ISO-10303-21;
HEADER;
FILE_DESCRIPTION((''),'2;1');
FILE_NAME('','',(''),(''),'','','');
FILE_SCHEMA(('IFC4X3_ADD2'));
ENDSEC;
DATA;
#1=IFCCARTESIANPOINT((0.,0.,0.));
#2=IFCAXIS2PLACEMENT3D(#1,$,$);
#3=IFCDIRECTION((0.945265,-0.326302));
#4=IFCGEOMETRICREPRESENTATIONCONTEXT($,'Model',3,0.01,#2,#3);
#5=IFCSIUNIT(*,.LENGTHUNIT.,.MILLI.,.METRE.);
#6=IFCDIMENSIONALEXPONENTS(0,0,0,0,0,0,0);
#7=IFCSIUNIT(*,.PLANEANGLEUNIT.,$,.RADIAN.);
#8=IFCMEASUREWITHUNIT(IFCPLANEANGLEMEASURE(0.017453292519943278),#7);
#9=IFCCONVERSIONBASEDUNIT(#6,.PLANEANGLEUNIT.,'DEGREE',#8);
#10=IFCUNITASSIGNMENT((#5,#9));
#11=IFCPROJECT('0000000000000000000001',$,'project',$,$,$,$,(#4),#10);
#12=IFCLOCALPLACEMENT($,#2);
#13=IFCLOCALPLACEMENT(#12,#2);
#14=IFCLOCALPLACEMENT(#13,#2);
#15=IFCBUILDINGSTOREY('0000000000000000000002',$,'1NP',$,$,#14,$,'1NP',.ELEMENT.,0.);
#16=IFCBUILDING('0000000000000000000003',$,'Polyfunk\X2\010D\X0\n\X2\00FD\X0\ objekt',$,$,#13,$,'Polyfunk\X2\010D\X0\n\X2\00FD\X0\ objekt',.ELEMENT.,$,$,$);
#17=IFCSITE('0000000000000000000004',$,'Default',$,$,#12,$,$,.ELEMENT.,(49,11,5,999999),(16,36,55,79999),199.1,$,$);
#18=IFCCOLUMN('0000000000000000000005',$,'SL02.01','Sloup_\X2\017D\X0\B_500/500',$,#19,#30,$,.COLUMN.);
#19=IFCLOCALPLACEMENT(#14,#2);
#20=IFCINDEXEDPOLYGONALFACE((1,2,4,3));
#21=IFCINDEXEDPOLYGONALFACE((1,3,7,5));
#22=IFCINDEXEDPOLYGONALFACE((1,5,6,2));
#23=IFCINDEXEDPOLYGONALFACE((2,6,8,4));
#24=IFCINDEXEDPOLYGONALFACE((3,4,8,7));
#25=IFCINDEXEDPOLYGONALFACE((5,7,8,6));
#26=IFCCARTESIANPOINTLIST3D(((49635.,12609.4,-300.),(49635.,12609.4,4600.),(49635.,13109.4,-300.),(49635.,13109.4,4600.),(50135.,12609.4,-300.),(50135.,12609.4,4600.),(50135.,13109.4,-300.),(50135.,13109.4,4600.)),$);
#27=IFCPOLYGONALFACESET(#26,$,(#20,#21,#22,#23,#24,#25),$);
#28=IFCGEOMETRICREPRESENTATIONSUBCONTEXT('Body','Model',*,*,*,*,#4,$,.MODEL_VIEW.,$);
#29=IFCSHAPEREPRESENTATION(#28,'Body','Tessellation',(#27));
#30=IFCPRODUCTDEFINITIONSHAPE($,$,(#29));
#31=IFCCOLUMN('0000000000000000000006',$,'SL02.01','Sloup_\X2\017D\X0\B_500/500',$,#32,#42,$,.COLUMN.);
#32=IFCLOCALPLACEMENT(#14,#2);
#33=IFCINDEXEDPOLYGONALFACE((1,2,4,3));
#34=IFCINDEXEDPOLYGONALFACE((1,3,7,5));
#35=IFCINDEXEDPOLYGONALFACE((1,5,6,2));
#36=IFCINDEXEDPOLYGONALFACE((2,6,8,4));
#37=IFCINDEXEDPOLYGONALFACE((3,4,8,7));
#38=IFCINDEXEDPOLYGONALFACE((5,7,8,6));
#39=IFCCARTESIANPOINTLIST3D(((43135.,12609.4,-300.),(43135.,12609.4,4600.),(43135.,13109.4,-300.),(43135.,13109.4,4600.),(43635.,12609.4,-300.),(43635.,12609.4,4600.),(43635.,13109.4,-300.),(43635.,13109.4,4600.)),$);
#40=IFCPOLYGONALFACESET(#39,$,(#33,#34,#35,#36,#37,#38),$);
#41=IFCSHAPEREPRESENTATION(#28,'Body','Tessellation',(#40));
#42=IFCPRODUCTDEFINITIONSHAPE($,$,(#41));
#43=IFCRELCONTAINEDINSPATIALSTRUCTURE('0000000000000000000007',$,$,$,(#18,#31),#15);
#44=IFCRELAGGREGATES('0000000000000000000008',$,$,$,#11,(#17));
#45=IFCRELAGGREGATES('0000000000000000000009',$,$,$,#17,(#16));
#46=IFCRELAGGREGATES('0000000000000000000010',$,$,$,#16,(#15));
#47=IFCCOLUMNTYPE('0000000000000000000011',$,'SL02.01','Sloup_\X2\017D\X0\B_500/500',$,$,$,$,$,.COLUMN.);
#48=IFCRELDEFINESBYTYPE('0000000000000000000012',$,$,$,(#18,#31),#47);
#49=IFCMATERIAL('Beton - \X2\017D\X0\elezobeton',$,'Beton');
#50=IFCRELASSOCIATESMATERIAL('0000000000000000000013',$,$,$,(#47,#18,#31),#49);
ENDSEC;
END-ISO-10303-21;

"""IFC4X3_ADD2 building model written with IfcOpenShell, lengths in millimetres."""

from ifc_helpers import new_model, entity, si_unit, converted_unit, direction, frame, frame_2d, origin, origin_2d_with_axis, place, context, subcontext, project, spatial, rectangle, extrude, source, transform, mapped, material, material_profile, profile_set, profile_usage, type_object, element, save


model = new_model("IFC4X3_ADD2")

# Units and contexts
model_context = context("Model", 3, precision=0.01, world=origin(), true_north=direction((0.945265, -0.326302)))
body_context = subcontext(model_context, "Body", "Model", "MODEL_VIEW")
ifc_project = project(units=[si_unit("LENGTHUNIT", "METRE", prefix="MILLI"), converted_unit("PLANEANGLEUNIT", "DEGREE", entity("IfcPlaneAngleMeasure", 0.017453292519943278), si_unit("PLANEANGLEUNIT", "RADIAN"), dimensions=[0, 0, 0, 0, 0, 0, 0])], contexts=[model_context])

# Site, building, storey
site_placement = place(None, origin())
site = spatial("IfcSite", under=ifc_project, at=site_placement, Name="Default", CompositionType="ELEMENT", RefLatitude=(49, 11, 5, 999999), RefLongitude=(16, 36, 55, 79999), RefElevation=199.1)
building_placement = place(site_placement, origin())
building = spatial("IfcBuilding", under=site, at=building_placement, Name="Polyfunkčný objekt", LongName="Polyfunkčný objekt", CompositionType="ELEMENT")
storey_placement = place(building_placement, origin())
storey = spatial("IfcBuildingStorey", under=building, at=storey_placement, Name="1NP", LongName="1NP", CompositionType="ELEMENT", Elevation=0.0)

# Columns
ifc_material = material(Name="Beton - Železobeton", Category="Beton")
ifc_material_profile_1 = material_profile(ifc_material, rectangle(XDim=500.0, YDim=500.0, at=frame_2d((0.0, 0.0), x_axis=(1.0, 0.0))), Name="Sloup_ŽB_500/500")
ifc_profile_set_1 = profile_set([ifc_material_profile_1], Name="Sloup_ŽB_500/500")
ifc_profile_usage_1 = profile_usage(ifc_profile_set_1)
column_type_1 = type_object("IfcColumnType", Name="SL02.01", Description="Sloup_ŽB_500/500", PredefinedType="COLUMN", material=ifc_profile_set_1)
shared_shape_1 = source(origin(), body_context, "Body", "SweptSolid", [
    extrude(rectangle(XDim=500.0, YDim=500.0, at=frame_2d((0.0, -50.0), x_axis=(1.0, 0.0))), frame((49885.0, 12809.4, -300.0), z_axis=(0.0, 0.0, 1.0), x_axis=(-1.0, 0.0, 0.0)), (0.0, 0.0, 1.0), 4900.0),
])
column_1_placement = place(storey_placement, origin())
element("IfcColumn", 1, at=column_1_placement, inside=storey, type_object=column_type_1, material=ifc_profile_usage_1, Name="SL02.01", Description="Sloup_ŽB_500/500", PredefinedType="COLUMN", context=body_context, shape_type="MappedRepresentation", body=[
    mapped(shared_shape_1, transform((0.0, 0.0, 0.0), scale=1.0)),
])
shared_shape_2 = source(origin(), body_context, "Body", "SweptSolid", [
    extrude(rectangle(XDim=500.0, YDim=500.0, at=origin_2d_with_axis()), frame((43385.0, 12859.4, -300.0), z_axis=(0.0, 0.0, 1.0), x_axis=(0.0, 1.0, 0.0)), (0.0, 0.0, 1.0), 4900.0),
])
column_2_placement = place(storey_placement, origin())
element("IfcColumn", 2, at=column_2_placement, inside=storey, type_object=column_type_1, material=ifc_profile_usage_1, Name="SL02.01", Description="Sloup_ŽB_500/500", PredefinedType="COLUMN", context=body_context, shape_type="MappedRepresentation", body=[
    mapped(shared_shape_2, transform((0.0, 0.0, 0.0), scale=1.0)),
])

save(model, "model.ifc")
